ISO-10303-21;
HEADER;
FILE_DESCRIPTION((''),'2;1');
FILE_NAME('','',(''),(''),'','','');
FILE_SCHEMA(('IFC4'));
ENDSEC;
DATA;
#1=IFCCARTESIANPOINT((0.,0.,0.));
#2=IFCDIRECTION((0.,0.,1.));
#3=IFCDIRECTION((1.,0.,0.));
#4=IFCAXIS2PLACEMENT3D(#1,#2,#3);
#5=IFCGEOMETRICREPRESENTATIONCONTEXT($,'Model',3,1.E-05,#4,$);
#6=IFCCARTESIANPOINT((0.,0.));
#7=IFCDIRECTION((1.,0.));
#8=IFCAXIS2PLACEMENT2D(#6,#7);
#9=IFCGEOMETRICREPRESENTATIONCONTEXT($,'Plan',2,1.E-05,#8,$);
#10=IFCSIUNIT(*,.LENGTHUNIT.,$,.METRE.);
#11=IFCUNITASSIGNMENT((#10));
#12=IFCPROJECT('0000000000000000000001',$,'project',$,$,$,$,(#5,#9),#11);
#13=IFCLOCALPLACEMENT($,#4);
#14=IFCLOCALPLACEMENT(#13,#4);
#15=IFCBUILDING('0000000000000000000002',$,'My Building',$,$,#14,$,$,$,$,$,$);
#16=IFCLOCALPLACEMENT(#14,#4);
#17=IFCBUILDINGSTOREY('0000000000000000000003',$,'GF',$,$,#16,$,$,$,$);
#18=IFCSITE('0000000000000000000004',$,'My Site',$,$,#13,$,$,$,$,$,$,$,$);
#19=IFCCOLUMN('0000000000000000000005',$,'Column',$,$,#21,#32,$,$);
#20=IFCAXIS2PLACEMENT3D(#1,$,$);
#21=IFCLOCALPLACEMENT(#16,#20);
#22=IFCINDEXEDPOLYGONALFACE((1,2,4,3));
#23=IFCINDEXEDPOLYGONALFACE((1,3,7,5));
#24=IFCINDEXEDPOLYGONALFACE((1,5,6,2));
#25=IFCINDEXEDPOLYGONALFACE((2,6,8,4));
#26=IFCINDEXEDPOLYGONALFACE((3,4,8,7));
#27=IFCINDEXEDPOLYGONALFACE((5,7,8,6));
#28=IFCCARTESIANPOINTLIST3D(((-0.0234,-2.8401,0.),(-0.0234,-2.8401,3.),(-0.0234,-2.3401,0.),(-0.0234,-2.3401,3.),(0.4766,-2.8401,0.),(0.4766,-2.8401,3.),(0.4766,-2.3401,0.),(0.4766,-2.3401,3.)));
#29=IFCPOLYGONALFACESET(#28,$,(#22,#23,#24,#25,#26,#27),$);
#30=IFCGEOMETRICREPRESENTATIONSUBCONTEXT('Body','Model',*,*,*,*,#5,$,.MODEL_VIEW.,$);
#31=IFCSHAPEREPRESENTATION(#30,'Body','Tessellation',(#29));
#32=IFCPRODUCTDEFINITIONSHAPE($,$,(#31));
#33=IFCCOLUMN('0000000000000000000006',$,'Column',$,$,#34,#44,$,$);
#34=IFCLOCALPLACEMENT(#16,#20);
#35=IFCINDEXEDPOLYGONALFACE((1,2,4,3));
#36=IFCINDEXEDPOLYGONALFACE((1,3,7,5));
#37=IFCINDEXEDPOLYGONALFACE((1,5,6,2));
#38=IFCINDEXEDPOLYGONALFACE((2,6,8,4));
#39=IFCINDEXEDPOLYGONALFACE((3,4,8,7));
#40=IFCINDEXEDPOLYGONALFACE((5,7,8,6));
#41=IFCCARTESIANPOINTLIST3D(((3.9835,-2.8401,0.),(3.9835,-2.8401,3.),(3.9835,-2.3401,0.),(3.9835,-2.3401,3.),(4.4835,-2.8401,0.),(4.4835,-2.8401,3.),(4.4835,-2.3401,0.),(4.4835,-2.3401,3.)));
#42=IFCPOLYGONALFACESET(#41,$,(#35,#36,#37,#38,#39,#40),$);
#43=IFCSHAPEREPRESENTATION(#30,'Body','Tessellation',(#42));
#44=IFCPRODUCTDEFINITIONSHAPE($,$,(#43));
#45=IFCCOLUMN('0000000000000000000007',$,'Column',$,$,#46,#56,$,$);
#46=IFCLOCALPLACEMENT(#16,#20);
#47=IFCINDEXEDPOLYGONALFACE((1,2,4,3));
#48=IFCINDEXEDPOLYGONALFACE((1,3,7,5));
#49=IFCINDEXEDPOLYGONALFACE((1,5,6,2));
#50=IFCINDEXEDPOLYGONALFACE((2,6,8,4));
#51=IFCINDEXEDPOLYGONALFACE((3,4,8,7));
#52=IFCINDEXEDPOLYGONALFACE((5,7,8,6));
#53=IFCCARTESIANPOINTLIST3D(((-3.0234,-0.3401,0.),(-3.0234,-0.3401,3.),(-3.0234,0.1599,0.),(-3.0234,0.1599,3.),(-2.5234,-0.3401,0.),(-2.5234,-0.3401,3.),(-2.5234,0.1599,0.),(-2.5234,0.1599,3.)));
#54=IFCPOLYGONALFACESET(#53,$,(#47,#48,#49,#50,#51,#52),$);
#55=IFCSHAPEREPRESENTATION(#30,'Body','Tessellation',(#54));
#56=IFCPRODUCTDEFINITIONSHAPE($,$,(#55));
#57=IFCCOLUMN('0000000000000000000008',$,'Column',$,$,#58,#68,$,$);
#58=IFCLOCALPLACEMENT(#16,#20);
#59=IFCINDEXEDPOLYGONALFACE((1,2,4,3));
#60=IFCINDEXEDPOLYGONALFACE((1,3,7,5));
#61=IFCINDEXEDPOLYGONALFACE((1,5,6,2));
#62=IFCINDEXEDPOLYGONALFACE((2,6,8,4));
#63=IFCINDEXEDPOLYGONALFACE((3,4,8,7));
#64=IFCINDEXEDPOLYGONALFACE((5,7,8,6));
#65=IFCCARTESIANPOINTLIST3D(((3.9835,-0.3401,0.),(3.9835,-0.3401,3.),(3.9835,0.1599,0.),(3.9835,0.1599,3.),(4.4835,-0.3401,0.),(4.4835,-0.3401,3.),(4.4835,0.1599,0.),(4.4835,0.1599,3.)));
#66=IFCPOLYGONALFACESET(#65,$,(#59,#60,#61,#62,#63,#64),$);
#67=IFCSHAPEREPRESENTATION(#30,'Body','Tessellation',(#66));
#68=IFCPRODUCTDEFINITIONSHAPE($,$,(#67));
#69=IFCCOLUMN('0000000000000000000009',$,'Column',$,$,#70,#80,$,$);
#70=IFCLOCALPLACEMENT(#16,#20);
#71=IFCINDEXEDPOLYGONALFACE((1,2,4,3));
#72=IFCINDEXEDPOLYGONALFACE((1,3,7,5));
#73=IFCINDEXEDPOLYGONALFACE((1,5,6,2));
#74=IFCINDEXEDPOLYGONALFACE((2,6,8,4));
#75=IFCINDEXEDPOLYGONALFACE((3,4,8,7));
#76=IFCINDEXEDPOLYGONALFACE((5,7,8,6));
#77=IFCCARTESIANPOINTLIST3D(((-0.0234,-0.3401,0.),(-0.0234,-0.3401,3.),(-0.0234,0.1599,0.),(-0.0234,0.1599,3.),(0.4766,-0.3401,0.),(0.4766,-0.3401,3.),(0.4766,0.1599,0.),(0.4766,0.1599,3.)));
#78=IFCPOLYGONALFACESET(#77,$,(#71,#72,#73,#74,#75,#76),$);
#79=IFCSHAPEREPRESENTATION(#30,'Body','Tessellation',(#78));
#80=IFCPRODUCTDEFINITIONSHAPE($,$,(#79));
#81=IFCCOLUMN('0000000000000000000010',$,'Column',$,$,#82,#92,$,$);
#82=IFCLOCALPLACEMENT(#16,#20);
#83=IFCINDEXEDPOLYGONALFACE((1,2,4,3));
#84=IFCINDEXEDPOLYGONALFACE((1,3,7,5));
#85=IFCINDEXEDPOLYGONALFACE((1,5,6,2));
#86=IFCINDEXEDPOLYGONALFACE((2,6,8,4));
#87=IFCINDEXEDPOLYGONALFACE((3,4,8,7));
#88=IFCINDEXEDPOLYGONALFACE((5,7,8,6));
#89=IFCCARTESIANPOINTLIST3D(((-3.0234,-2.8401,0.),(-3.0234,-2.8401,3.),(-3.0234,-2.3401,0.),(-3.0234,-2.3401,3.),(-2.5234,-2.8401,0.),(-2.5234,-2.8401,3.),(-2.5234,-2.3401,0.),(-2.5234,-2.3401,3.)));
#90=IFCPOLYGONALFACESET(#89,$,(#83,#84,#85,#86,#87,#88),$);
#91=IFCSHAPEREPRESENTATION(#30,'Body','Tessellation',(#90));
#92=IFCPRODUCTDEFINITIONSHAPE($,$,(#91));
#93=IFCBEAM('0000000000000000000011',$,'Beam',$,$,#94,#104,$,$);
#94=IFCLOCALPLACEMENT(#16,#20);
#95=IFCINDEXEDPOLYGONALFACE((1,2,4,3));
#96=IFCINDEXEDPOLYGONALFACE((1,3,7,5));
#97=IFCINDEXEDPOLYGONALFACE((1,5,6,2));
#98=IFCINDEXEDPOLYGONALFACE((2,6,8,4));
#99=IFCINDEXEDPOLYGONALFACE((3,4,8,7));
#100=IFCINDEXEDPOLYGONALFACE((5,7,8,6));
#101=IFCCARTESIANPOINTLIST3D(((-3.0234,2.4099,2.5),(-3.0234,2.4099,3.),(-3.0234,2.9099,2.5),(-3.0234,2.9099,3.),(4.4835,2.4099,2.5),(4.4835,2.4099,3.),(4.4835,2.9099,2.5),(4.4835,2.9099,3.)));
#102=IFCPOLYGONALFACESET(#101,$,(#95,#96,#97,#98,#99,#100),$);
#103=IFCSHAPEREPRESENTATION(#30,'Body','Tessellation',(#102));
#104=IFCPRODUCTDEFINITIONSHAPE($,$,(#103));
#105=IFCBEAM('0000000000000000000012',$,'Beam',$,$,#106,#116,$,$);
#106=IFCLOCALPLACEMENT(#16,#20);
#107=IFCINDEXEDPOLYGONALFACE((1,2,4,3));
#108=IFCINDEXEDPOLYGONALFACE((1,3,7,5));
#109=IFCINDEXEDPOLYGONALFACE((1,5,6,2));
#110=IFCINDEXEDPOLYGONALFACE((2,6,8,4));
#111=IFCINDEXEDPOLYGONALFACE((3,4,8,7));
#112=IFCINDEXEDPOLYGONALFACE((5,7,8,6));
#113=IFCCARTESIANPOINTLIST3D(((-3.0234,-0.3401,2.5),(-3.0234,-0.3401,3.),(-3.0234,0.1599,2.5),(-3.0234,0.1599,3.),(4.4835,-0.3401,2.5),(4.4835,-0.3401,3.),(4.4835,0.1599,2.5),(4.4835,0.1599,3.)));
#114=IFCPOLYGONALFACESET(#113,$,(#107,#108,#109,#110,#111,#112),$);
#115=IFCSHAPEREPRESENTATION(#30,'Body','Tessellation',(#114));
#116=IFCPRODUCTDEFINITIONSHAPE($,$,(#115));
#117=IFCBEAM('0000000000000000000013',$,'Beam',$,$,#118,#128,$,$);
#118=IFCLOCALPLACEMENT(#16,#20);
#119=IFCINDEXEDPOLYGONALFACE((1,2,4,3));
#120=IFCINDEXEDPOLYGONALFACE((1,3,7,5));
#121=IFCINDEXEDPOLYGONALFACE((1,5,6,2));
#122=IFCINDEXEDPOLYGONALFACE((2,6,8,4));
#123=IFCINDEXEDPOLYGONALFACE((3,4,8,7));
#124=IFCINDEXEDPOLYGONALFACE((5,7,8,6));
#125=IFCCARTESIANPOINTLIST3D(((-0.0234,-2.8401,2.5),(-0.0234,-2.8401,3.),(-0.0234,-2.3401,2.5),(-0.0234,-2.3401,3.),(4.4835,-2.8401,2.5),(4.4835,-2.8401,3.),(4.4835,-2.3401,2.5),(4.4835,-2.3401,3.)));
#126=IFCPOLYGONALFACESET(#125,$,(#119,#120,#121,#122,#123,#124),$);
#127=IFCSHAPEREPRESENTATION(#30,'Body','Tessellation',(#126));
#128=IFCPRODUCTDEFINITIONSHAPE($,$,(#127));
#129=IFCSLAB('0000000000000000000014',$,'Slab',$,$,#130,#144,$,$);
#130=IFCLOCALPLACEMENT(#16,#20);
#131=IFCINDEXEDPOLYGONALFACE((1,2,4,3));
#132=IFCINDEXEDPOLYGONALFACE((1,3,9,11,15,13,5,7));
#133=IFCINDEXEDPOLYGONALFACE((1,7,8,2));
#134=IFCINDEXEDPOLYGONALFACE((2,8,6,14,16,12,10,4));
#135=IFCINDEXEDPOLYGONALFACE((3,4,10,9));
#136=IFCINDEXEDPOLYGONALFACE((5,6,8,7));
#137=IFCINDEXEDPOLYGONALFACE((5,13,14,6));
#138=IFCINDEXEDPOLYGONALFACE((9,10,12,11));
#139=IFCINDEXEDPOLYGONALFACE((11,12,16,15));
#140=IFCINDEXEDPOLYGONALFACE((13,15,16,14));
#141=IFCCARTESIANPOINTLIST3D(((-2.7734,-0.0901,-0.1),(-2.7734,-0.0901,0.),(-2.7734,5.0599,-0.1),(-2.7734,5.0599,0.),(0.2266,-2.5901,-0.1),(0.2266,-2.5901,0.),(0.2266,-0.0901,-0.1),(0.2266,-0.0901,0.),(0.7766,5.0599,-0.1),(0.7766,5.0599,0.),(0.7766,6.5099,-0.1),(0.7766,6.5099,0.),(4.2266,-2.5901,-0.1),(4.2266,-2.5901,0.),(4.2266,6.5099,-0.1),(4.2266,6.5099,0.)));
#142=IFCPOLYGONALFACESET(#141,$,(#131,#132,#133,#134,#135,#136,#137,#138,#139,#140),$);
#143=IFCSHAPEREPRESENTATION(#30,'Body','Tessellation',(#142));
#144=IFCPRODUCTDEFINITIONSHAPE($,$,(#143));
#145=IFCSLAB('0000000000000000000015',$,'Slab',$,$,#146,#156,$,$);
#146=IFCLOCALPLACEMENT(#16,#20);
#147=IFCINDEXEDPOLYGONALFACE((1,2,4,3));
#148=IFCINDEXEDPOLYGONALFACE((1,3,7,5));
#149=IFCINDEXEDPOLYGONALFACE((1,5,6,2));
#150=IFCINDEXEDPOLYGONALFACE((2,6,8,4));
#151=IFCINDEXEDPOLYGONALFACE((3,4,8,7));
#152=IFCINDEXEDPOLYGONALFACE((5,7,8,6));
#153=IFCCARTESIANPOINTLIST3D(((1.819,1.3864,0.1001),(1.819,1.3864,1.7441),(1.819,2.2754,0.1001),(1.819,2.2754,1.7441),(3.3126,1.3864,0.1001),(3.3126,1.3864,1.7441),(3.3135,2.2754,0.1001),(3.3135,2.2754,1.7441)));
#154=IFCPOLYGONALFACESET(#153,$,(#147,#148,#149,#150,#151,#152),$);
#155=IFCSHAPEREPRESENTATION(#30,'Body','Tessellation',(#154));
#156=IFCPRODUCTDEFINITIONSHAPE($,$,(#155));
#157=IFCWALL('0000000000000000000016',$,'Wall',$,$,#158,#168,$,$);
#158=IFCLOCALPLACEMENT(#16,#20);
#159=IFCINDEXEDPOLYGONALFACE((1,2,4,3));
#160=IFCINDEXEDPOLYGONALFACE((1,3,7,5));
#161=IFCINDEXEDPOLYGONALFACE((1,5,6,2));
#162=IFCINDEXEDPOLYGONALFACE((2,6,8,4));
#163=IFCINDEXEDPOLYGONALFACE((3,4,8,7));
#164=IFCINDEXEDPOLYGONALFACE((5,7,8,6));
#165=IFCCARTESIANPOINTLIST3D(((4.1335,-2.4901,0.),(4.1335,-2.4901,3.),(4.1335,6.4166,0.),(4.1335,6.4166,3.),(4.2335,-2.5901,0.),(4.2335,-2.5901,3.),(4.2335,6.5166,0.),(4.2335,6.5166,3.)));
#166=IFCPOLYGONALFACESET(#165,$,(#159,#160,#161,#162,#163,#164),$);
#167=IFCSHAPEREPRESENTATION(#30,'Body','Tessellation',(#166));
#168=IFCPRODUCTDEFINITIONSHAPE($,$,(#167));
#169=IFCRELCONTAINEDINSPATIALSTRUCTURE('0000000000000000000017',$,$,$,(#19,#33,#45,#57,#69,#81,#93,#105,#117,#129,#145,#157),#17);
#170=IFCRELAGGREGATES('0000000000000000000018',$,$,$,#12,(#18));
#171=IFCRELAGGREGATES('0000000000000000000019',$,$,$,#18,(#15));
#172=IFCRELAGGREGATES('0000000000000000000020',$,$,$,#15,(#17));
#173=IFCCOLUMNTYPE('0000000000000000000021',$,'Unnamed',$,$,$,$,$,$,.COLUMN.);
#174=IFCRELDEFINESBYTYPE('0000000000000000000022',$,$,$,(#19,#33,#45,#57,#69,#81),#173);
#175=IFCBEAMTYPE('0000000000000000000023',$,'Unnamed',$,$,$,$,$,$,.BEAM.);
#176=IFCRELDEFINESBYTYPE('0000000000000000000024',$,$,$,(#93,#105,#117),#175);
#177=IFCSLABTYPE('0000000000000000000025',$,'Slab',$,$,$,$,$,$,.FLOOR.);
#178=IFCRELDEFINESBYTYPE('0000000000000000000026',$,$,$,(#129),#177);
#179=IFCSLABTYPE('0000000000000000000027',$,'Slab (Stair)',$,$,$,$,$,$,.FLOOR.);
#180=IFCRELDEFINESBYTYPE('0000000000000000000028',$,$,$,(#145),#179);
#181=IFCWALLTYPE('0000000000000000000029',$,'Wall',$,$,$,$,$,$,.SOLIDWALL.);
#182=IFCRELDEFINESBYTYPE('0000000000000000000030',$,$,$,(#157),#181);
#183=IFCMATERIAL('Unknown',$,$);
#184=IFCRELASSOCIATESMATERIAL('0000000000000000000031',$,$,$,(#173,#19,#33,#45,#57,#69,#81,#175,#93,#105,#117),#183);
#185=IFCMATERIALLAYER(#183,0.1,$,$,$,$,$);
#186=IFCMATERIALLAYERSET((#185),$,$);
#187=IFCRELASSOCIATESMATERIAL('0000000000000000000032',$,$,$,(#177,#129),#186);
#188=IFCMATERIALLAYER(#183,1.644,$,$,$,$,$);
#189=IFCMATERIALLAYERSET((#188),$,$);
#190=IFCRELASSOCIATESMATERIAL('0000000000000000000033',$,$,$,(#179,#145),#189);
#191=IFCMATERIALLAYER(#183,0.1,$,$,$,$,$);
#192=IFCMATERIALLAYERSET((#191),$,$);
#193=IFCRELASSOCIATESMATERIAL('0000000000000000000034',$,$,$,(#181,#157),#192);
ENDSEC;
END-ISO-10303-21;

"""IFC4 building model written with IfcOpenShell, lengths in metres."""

from ifc_helpers import new_model, si_unit, frame, origin_with_axes, origin_2d_with_axis, place, context, subcontext, project, spatial, line, indexed_curve, rectangle, outline, extrude, material, layer, layer_set, layer_usage, material_profile, profile_set, profile_usage, type_object, element, save


model = new_model("IFC4")

# Units and contexts
model_context = context("Model", 3, precision=1e-05, world=origin_with_axes())
plan_context = context("Plan", 2, precision=1e-05, world=origin_2d_with_axis())
body_context_1 = subcontext(model_context, "Body", "Model", "MODEL_VIEW")
ifc_project = project(units=[si_unit("LENGTHUNIT", "METRE")], contexts=[model_context, plan_context])

# Site, building, storey
site_placement = place(None, origin_with_axes())
site = spatial("IfcSite", under=ifc_project, at=site_placement, Name="My Site")
building_placement = place(site_placement, origin_with_axes())
building = spatial("IfcBuilding", under=site, at=building_placement, Name="My Building")
storey_placement = place(building_placement, origin_with_axes())
storey = spatial("IfcBuildingStorey", under=building, at=storey_placement, Name="GF")

# Columns
ifc_material = material(Name="Unknown")
ifc_material_profile_1 = material_profile(ifc_material, rectangle(XDim=0.5, YDim=0.5))
ifc_profile_set_1 = profile_set([ifc_material_profile_1])
ifc_profile_usage_1 = profile_usage(ifc_profile_set_1, cardinal=5)
column_type = type_object("IfcColumnType", Name="Unnamed", PredefinedType="COLUMN", material=ifc_profile_set_1)
column_1_placement = place(storey_placement, frame((0.2266, -2.5901, 0.0), z_axis=(0.0, 0.0, 1.0), x_axis=(1.0, 0.0, 0.0)))
element("IfcColumn", 1, at=column_1_placement, inside=storey, type_object=column_type, material=ifc_profile_usage_1, Name="Column", context=body_context_1, shape_type="SweptSolid", body=[
    extrude(rectangle(XDim=0.5, YDim=0.5), origin_with_axes(), (0.0, 0.0, 1.0), 3.0),
])
ifc_profile_usage_2 = profile_usage(ifc_profile_set_1, cardinal=5)
column_2_placement = place(storey_placement, frame((4.2335, -2.5901, 0.0), z_axis=(0.0, 0.0, 1.0), x_axis=(1.0, 0.0, 0.0)))
element("IfcColumn", 2, at=column_2_placement, inside=storey, type_object=column_type, material=ifc_profile_usage_2, Name="Column", context=body_context_1, shape_type="SweptSolid", body=[
    extrude(rectangle(XDim=0.5, YDim=0.5), origin_with_axes(), (0.0, 0.0, 1.0), 3.0),
])
ifc_profile_usage_3 = profile_usage(ifc_profile_set_1, cardinal=5)
column_3_placement = place(storey_placement, frame((-2.7734, -0.0901, 0.0), z_axis=(0.0, 0.0, 1.0), x_axis=(1.0, 0.0, 0.0)))
element("IfcColumn", 3, at=column_3_placement, inside=storey, type_object=column_type, material=ifc_profile_usage_3, Name="Column", context=body_context_1, shape_type="SweptSolid", body=[
    extrude(rectangle(XDim=0.5, YDim=0.5), origin_with_axes(), (0.0, 0.0, 1.0), 3.0),
])
ifc_profile_usage_4 = profile_usage(ifc_profile_set_1, cardinal=5)
column_4_placement = place(storey_placement, frame((4.2335, -0.0901, 0.0), z_axis=(0.0, 0.0, 1.0), x_axis=(1.0, 0.0, 0.0)))
element("IfcColumn", 4, at=column_4_placement, inside=storey, type_object=column_type, material=ifc_profile_usage_4, Name="Column", context=body_context_1, shape_type="SweptSolid", body=[
    extrude(rectangle(XDim=0.5, YDim=0.5), origin_with_axes(), (0.0, 0.0, 1.0), 3.0),
])
ifc_profile_usage_5 = profile_usage(ifc_profile_set_1, cardinal=5)
column_5_placement = place(storey_placement, frame((0.2266, -0.0901, 0.0), z_axis=(0.0, 0.0, 1.0), x_axis=(1.0, 0.0, 0.0)))
element("IfcColumn", 5, at=column_5_placement, inside=storey, type_object=column_type, material=ifc_profile_usage_5, Name="Column", context=body_context_1, shape_type="SweptSolid", body=[
    extrude(rectangle(XDim=0.5, YDim=0.5), origin_with_axes(), (0.0, 0.0, 1.0), 3.0),
])
ifc_profile_usage_6 = profile_usage(ifc_profile_set_1, cardinal=5)
column_6_placement = place(storey_placement, frame((-2.7734, -2.5901, 0.0), z_axis=(0.0, 0.0, 1.0), x_axis=(1.0, 0.0, 0.0)))
element("IfcColumn", 6, at=column_6_placement, inside=storey, type_object=column_type, material=ifc_profile_usage_6, Name="Column", context=body_context_1, shape_type="SweptSolid", body=[
    extrude(rectangle(XDim=0.5, YDim=0.5), origin_with_axes(), (0.0, 0.0, 1.0), 3.0),
])

# Beams
ifc_material_profile_2 = material_profile(ifc_material, rectangle(XDim=0.5, YDim=0.5))
ifc_profile_set_2 = profile_set([ifc_material_profile_2])
ifc_profile_usage_7 = profile_usage(ifc_profile_set_2, cardinal=7)
beam_type = type_object("IfcBeamType", Name="Unnamed", PredefinedType="BEAM", material=ifc_profile_set_2)
beam_1_placement = place(storey_placement, frame((4.4835, 2.4099, 3.0), z_axis=(-1.0, 0.0, 0.0), x_axis=(0.0, -1.0, 0.0)))
element("IfcBeam", 7, at=beam_1_placement, inside=storey, type_object=beam_type, material=ifc_profile_usage_7, Name="Beam", context=body_context_1, shape_type="SweptSolid", body=[
    extrude(rectangle(XDim=0.5, YDim=0.5), frame((-0.25, -0.25, 0.0), z_axis=(0.0, 0.0, 1.0), x_axis=(1.0, 0.0, 0.0)), (0.0, 0.0, 1.0), 7.5069),
])
ifc_profile_usage_8 = profile_usage(ifc_profile_set_2, cardinal=7)
beam_2_placement = place(storey_placement, frame((4.4835, -0.3401, 3.0), z_axis=(-1.0, 0.0, 0.0), x_axis=(0.0, -1.0, 0.0)))
element("IfcBeam", 8, at=beam_2_placement, inside=storey, type_object=beam_type, material=ifc_profile_usage_8, Name="Beam", context=body_context_1, shape_type="SweptSolid", body=[
    extrude(rectangle(XDim=0.5, YDim=0.5), frame((-0.25, -0.25, 0.0), z_axis=(0.0, 0.0, 1.0), x_axis=(1.0, 0.0, 0.0)), (0.0, 0.0, 1.0), 7.5069),
])
ifc_profile_usage_9 = profile_usage(ifc_profile_set_2, cardinal=7)
beam_3_placement = place(storey_placement, frame((-0.0234, -2.3401, 3.0), z_axis=(1.0, 0.0, 0.0), x_axis=(0.0, 1.0, 0.0)))
element("IfcBeam", 9, at=beam_3_placement, inside=storey, type_object=beam_type, material=ifc_profile_usage_9, Name="Beam", context=body_context_1, shape_type="SweptSolid", body=[
    extrude(rectangle(XDim=0.5, YDim=0.5), frame((-0.25, -0.25, 0.0), z_axis=(0.0, 0.0, 1.0), x_axis=(1.0, 0.0, 0.0)), (0.0, 0.0, 1.0), 4.5069),
])

# Slabs
ifc_layer_1 = layer(ifc_material, 0.1)
ifc_layer_set_1 = layer_set([ifc_layer_1])
ifc_layer_usage_1 = layer_usage(ifc_layer_set_1, "AXIS3", "POSITIVE", -0.1)
slab_type_1 = type_object("IfcSlabType", Name="Slab", PredefinedType="FLOOR", material=ifc_layer_set_1)
slab_1_placement = place(storey_placement, frame((4.2266, -2.5901, 0.0), z_axis=(0.0, 0.0, 1.0), x_axis=(1.0, 0.0, 0.0)))
element("IfcSlab", 10, at=slab_1_placement, inside=storey, type_object=slab_type_1, material=ifc_layer_usage_1, Name="Slab", context=body_context_1, shape_type="SweptSolid", body=[
    extrude(outline(indexed_curve([(0.0, 0.0), (0.0, 9.1), (-3.45, 9.1), (-3.45, 7.65), (-7.0, 7.65), (-7.0, 2.5), (-4.0, 2.5), (-4.0, 0.0), (0.0, 0.0)])), frame((0.0, 0.0, -0.1), z_axis=(0.0, 0.0, 1.0), x_axis=(1.0, 0.0, 0.0)), (0.0, 0.0, 1.0), 0.1),
])
ifc_layer_2 = layer(ifc_material, 1.644)
ifc_layer_set_2 = layer_set([ifc_layer_2])
ifc_layer_usage_2 = layer_usage(ifc_layer_set_2, "AXIS3", "POSITIVE", -0.1)
slab_type_2 = type_object("IfcSlabType", Name="Slab (Stair)", PredefinedType="FLOOR", material=ifc_layer_set_2)
slab_2_placement = place(storey_placement, frame((3.3126, 2.2754, 0.2001), z_axis=(0.0, 0.0, 1.0), x_axis=(1.0, 0.0, 0.0)))
element("IfcSlab", 11, at=slab_2_placement, inside=storey, type_object=slab_type_2, material=ifc_layer_usage_2, Name="Slab", context=body_context_1, shape_type="SweptSolid", body=[
    extrude(outline(indexed_curve([(-1.4936, 0.0), (-1.4936, -0.8889), (0.0, -0.8889), (0.0009, 0.0), (-1.4936, 0.0)])), frame((0.0, 0.0, -0.1), z_axis=(0.0, 0.0, 1.0), x_axis=(1.0, 0.0, 0.0)), (0.0, 0.0, 1.0), 1.644),
])

# Shared definitions
ifc_layer_3 = layer(ifc_material, 0.1)
ifc_layer_set_3 = layer_set([ifc_layer_3])
wall_type = type_object("IfcWallType", Name="Wall", PredefinedType="SOLIDWALL", material=ifc_layer_set_3)

# Wall
ifc_layer_usage_3 = layer_usage(ifc_layer_set_3, "AXIS2", "POSITIVE", 0.0)
wall_1_placement = place(storey_placement, frame((4.2335, -2.5901, 0.0), z_axis=(0.0, 0.0, 1.0), x_axis=(0.0, 1.0, 0.0)))
element("IfcWall", 12, at=wall_1_placement, inside=storey, type_object=wall_type, material=ifc_layer_usage_3, Name="Wall", context=body_context_1, shape_type="SweptSolid", body=[
    extrude(outline(indexed_curve([(0.0, 0.0), (0.1, 0.1), (9.0067, 0.1), (9.1067, 0.0)], segments=[line(1, 2, 3, 4, 1)])), origin_with_axes(), (0.0, 0.0, 1.0), 3.0),
])

save(model, "model.ifc")
